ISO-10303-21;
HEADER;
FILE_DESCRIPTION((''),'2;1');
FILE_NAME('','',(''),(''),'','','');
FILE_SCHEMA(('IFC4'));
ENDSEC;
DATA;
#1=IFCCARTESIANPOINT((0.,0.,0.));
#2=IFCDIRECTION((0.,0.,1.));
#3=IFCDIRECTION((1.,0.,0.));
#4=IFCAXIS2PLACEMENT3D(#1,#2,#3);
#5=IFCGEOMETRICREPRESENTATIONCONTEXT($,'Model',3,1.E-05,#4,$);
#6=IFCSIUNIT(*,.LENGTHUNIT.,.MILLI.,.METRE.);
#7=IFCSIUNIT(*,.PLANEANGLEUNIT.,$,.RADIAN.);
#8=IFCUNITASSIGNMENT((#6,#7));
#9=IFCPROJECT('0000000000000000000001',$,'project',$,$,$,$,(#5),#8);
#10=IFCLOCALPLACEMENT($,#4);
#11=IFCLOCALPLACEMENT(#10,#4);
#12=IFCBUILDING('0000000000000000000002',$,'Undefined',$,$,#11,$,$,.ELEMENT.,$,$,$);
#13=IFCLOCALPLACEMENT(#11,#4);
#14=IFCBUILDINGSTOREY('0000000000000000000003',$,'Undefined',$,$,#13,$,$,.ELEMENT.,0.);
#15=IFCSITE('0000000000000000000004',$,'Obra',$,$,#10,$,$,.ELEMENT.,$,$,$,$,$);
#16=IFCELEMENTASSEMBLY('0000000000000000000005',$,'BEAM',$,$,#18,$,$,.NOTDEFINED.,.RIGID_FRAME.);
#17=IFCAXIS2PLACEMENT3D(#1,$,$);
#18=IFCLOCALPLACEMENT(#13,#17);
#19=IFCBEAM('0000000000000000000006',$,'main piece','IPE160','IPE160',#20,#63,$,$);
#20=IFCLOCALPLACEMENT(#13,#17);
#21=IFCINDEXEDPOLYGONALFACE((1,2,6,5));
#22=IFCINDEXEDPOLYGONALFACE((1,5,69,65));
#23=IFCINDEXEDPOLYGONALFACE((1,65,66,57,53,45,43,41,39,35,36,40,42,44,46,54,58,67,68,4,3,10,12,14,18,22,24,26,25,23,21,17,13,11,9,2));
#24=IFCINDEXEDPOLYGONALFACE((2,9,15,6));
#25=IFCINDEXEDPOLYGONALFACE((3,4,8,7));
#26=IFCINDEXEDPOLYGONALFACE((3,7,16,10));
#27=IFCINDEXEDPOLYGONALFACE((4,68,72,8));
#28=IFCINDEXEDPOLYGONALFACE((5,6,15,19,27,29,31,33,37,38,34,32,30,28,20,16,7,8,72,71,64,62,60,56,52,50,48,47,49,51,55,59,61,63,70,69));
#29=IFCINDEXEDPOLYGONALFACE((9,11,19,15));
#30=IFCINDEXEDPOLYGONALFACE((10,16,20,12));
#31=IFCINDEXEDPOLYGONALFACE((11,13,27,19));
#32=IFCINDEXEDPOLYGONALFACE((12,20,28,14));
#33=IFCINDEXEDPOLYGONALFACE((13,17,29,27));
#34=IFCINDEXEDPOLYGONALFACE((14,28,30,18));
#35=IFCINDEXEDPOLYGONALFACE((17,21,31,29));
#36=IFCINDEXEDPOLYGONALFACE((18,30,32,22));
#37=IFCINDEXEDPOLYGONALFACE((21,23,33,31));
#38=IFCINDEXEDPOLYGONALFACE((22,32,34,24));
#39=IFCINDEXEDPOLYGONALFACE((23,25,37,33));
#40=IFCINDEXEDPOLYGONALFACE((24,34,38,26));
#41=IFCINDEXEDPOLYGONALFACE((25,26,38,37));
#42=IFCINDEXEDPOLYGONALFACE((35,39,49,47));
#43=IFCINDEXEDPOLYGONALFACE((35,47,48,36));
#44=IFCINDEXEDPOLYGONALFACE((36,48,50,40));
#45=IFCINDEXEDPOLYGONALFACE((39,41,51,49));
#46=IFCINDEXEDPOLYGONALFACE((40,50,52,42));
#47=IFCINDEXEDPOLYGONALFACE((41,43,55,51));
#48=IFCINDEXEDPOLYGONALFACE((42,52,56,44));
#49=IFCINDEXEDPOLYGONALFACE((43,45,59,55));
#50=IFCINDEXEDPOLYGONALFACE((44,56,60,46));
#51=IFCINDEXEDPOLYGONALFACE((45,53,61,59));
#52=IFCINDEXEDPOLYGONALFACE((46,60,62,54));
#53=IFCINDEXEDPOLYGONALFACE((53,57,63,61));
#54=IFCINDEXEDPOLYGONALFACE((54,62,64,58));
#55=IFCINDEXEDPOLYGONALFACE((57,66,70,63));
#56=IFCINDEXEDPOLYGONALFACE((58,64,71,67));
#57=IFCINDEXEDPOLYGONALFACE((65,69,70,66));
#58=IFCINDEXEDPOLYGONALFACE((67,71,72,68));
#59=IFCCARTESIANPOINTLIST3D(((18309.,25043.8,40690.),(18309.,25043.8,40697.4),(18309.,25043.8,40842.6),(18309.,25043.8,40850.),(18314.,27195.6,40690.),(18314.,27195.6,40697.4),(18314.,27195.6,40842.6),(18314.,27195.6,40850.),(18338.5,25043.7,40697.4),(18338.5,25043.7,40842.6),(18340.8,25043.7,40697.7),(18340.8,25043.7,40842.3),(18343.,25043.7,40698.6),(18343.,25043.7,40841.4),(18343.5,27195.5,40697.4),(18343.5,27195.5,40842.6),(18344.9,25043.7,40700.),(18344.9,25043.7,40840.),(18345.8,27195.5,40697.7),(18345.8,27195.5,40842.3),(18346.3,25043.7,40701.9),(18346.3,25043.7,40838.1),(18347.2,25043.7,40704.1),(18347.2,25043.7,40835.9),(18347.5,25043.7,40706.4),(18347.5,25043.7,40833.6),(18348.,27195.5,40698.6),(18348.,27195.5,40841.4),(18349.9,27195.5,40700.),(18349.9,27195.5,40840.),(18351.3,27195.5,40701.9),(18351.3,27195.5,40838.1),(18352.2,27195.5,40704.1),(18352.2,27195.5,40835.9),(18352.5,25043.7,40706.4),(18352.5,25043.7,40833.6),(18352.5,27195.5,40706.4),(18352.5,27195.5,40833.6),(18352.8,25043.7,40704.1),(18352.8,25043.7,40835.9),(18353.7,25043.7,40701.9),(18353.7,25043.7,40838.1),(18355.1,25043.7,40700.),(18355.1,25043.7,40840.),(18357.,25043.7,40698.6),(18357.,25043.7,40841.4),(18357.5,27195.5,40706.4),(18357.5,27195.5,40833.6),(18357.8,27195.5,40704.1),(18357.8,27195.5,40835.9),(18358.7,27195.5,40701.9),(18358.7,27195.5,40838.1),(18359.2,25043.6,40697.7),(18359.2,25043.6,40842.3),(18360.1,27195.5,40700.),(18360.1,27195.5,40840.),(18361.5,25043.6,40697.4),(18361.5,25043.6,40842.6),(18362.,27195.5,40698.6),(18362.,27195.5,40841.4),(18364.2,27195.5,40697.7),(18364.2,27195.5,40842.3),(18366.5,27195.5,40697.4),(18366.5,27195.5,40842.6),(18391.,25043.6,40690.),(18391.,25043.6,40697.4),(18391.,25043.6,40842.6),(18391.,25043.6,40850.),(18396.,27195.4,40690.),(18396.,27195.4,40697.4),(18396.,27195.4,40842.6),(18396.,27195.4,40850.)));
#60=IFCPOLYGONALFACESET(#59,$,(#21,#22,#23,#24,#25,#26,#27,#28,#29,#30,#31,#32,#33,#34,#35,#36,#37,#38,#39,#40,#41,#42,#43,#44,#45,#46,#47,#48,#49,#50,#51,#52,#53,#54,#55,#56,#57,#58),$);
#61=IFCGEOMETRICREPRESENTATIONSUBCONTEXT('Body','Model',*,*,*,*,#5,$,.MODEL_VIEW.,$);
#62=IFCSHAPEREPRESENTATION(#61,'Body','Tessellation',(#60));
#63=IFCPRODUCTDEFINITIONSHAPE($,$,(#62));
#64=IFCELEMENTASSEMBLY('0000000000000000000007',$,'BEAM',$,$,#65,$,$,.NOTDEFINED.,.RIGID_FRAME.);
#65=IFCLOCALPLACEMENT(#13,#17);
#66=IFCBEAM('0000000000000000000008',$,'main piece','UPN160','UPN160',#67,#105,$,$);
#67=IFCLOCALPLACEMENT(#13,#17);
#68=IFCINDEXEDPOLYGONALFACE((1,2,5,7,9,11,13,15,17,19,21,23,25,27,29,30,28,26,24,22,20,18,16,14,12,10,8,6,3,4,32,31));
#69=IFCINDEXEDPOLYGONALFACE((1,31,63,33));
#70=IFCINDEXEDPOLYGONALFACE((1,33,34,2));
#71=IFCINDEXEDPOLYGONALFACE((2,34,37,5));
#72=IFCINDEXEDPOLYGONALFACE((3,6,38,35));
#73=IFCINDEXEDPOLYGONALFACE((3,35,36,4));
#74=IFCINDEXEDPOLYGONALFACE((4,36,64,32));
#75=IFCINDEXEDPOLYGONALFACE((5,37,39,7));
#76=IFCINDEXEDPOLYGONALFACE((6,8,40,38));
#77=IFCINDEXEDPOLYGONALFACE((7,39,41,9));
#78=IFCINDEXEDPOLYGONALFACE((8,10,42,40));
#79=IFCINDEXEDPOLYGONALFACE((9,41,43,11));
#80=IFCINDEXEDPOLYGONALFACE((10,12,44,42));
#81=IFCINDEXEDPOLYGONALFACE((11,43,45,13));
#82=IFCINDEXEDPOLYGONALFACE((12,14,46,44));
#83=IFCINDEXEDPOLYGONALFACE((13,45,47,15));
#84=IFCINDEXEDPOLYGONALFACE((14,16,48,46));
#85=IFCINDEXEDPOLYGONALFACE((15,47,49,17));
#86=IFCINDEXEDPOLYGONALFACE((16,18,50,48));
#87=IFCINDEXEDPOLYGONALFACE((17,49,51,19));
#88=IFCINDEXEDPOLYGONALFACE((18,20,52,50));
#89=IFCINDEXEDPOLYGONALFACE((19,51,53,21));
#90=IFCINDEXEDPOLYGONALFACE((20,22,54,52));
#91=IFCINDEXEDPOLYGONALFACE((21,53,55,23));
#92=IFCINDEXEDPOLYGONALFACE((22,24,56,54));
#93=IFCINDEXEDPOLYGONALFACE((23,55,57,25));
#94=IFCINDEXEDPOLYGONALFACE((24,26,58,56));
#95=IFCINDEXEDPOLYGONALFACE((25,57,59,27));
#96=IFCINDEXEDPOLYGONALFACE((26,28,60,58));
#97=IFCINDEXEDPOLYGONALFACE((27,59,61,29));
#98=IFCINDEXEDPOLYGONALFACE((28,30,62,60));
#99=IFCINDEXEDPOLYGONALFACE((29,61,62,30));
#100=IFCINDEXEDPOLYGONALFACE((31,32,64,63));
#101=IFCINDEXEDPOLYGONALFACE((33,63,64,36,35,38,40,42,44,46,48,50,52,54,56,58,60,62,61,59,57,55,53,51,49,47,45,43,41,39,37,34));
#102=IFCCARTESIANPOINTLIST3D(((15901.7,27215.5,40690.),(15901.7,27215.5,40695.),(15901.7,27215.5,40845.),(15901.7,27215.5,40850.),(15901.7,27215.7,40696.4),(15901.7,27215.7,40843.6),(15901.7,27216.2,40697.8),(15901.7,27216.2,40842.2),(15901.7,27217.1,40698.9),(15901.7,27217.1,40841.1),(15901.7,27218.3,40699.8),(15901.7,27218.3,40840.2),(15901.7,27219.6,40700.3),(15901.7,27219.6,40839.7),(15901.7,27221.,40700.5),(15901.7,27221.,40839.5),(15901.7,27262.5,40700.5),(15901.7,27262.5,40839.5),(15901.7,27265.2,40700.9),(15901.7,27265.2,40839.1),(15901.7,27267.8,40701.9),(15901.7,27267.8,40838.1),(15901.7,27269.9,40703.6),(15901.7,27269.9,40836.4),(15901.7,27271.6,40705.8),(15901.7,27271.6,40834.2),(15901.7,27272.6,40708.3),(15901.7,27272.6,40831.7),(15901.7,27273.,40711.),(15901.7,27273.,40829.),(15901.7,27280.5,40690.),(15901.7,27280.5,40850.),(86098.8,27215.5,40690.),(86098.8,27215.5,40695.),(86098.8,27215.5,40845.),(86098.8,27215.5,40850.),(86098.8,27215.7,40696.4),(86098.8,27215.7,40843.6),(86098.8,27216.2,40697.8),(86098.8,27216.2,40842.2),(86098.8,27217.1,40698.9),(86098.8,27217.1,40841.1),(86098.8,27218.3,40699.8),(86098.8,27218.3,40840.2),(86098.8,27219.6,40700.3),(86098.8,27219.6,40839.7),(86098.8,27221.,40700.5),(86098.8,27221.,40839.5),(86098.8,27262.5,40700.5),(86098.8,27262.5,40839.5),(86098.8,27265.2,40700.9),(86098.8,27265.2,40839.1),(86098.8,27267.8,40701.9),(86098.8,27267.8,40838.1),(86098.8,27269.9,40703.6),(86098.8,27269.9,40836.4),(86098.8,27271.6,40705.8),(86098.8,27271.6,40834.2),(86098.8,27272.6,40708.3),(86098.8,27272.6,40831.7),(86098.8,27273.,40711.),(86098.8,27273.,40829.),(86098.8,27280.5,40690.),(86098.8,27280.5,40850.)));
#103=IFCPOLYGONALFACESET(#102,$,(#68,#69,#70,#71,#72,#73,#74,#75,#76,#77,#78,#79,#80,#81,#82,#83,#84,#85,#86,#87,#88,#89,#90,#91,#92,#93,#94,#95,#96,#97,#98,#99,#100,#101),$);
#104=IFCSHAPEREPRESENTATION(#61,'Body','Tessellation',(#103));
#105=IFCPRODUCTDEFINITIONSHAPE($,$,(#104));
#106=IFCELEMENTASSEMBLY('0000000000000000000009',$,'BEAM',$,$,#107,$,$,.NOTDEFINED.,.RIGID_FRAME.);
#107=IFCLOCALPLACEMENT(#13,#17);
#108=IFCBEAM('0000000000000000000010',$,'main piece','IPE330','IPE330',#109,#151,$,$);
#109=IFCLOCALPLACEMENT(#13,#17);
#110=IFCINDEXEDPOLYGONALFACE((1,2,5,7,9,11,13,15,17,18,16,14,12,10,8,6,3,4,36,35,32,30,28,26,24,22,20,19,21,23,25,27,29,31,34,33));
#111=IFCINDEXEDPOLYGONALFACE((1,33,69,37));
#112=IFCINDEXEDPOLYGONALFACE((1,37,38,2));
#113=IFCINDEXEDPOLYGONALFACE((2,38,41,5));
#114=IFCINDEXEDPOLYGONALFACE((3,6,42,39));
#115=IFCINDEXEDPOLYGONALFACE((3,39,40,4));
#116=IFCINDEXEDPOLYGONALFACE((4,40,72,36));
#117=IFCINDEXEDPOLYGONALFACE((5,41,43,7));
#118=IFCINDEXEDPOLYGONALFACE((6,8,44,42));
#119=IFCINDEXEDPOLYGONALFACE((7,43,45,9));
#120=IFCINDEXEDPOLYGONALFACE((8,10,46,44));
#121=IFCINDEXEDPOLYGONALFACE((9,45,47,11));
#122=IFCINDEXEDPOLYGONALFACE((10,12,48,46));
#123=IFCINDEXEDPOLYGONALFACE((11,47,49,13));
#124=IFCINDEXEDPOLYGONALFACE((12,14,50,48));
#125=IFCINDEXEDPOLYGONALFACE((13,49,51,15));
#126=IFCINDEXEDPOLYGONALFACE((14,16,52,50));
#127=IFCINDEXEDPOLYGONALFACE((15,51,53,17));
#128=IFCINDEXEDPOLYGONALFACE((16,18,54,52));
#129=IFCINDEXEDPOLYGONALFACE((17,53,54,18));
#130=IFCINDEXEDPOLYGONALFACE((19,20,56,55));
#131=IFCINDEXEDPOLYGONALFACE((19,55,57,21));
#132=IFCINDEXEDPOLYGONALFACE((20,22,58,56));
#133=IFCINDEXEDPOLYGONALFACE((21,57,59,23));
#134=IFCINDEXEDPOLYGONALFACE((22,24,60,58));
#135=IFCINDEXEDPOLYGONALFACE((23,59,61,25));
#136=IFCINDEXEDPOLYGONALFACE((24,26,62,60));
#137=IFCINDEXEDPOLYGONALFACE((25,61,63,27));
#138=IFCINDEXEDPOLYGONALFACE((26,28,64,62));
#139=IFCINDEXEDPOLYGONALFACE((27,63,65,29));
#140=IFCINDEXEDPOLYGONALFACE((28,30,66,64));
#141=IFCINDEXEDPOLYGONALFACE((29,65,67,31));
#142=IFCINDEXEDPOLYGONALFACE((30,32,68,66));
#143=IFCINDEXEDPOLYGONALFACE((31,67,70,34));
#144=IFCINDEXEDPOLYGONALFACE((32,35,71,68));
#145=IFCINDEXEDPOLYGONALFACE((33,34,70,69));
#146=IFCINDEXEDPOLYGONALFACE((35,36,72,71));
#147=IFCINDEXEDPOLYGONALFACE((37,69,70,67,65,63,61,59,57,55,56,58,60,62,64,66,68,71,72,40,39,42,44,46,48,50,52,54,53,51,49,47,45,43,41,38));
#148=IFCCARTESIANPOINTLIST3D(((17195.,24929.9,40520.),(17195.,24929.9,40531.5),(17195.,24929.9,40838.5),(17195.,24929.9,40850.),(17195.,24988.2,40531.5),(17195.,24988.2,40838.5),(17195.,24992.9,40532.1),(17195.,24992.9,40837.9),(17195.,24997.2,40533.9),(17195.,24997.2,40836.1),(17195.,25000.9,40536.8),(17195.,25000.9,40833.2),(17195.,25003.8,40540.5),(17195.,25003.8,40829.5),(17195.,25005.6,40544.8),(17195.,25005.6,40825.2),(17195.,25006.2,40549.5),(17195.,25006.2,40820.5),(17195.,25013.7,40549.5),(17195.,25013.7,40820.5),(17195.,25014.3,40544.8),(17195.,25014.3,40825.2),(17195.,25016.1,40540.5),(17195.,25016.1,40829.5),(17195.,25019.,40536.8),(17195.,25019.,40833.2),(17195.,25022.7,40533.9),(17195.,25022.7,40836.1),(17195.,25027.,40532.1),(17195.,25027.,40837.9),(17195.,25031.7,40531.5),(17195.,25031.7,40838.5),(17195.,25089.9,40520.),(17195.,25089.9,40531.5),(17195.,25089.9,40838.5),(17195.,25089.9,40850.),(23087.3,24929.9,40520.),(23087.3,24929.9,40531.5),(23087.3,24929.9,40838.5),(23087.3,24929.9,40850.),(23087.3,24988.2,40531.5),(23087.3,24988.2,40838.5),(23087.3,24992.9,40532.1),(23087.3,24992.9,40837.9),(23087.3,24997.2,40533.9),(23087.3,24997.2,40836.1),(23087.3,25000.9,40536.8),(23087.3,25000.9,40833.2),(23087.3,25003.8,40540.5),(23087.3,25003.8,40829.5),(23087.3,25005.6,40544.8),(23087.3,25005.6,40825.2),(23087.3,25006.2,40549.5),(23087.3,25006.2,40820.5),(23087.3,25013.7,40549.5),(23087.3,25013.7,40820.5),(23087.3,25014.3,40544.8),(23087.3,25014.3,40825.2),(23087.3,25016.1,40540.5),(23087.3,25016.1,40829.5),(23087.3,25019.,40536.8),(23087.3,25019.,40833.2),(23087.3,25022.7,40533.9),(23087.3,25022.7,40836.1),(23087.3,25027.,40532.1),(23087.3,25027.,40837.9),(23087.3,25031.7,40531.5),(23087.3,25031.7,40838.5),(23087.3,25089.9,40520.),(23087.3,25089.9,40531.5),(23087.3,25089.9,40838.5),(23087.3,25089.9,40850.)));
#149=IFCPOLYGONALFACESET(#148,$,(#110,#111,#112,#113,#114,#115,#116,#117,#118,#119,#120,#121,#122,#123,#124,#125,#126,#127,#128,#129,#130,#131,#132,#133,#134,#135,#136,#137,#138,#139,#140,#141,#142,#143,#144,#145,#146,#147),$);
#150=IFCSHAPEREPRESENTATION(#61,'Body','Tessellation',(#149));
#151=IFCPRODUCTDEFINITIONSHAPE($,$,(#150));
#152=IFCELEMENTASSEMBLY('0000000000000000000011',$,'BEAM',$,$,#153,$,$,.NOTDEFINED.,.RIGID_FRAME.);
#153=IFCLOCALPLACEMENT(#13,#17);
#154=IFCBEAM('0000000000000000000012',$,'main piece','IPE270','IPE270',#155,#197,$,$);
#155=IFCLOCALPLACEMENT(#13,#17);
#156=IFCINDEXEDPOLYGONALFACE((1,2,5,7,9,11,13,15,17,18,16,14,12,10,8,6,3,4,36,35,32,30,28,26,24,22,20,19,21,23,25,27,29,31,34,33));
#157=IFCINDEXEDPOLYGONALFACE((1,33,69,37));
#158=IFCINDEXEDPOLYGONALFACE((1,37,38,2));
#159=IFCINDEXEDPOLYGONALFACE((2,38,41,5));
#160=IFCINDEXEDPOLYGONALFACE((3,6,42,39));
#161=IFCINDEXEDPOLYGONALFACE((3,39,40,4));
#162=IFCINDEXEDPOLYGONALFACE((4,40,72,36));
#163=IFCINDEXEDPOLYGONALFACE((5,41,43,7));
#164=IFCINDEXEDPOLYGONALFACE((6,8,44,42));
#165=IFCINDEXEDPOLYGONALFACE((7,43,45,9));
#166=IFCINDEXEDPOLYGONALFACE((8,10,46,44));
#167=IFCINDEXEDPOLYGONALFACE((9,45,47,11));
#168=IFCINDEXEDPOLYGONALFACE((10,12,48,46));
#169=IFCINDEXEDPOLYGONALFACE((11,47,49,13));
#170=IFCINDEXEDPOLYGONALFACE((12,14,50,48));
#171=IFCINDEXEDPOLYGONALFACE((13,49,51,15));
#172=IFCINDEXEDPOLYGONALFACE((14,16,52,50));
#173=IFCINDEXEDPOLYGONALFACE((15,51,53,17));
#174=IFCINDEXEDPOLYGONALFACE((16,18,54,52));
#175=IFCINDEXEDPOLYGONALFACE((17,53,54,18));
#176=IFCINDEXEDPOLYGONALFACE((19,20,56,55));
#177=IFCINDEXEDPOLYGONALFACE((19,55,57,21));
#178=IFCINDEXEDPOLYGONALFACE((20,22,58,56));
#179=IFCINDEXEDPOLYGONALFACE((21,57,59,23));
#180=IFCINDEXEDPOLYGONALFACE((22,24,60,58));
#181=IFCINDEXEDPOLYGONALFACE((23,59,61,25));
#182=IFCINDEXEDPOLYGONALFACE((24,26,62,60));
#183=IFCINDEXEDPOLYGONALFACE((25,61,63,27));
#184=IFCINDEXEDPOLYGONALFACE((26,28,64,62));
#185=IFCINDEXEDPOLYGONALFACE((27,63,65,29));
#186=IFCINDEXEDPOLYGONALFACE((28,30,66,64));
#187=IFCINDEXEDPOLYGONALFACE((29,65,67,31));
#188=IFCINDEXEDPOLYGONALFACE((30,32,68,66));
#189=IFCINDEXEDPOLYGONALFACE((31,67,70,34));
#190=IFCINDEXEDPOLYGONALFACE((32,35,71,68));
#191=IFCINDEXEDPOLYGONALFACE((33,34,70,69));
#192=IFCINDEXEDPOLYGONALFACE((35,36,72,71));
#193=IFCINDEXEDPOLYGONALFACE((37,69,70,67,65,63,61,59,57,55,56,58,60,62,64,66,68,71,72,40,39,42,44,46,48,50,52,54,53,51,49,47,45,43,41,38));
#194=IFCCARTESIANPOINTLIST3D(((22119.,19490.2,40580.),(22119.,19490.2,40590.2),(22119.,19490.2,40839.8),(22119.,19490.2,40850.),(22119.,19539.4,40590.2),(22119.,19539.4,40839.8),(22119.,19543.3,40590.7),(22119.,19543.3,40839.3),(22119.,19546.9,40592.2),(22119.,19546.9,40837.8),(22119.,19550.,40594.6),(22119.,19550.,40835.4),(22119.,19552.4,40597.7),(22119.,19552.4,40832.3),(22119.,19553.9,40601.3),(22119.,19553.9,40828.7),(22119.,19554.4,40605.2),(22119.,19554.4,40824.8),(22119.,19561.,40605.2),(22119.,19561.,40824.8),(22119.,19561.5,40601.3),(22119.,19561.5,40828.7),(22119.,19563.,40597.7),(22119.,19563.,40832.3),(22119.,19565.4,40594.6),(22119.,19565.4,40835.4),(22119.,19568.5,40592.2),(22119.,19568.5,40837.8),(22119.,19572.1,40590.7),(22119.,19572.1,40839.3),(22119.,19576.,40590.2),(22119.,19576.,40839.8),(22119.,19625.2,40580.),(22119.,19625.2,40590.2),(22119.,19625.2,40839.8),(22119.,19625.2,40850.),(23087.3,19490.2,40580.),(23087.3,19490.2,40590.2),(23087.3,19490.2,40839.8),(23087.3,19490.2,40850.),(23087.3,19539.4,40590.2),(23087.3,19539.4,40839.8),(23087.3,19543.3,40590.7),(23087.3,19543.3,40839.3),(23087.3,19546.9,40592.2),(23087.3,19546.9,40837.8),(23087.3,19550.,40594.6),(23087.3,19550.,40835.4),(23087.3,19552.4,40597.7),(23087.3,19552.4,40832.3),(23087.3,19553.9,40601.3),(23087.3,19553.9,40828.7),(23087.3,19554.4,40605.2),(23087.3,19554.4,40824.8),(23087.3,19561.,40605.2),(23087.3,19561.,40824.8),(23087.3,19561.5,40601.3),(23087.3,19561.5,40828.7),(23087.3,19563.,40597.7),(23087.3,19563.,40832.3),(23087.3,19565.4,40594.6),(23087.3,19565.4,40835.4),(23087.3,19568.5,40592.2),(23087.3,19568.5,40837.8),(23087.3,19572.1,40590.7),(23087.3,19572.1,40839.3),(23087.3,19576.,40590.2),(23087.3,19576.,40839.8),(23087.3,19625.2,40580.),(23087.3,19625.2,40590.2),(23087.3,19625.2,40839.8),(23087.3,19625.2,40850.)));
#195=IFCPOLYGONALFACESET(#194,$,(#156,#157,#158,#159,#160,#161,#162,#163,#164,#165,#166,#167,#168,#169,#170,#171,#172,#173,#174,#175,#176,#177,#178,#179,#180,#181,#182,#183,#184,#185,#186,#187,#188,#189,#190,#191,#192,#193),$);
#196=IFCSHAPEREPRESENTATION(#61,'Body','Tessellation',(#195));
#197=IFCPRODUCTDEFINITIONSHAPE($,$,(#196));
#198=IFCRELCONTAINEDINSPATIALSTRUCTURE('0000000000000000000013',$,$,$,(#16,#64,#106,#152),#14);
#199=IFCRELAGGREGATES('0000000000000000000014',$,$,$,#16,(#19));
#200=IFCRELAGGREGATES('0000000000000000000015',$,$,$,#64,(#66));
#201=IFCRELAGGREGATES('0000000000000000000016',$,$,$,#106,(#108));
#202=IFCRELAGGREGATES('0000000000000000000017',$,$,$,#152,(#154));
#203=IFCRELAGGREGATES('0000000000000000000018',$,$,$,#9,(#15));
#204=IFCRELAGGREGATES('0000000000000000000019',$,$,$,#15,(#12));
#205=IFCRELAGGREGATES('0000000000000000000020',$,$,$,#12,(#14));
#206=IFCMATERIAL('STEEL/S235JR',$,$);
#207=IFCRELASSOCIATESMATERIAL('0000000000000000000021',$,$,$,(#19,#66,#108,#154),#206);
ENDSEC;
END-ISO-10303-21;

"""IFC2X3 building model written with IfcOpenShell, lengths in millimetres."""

from ifc_helpers import new_model, si_unit, frame, origin_with_axes, origin_2d_with_axis, place, context, subcontext, project, spatial, i_section, u_section, extrude, material, element, aggregate, save


model = new_model("IFC2X3")

# Units and contexts
model_context = context("Model", 3, precision=1e-05, world=origin_with_axes())
body_context = subcontext(model_context, "Body", "Model", "MODEL_VIEW")
ifc_project = project(units=[si_unit("LENGTHUNIT", "METRE", prefix="MILLI"), si_unit("PLANEANGLEUNIT", "RADIAN")], contexts=[model_context])

# Site, building, storey
site_placement = place(None, origin_with_axes())
site = spatial("IfcSite", under=ifc_project, at=site_placement, Name="Obra", CompositionType="ELEMENT")
building_placement = place(site_placement, origin_with_axes())
building = spatial("IfcBuilding", under=site, at=building_placement, Name="Undefined", CompositionType="ELEMENT")
storey_placement = place(building_placement, origin_with_axes())
storey = spatial("IfcBuildingStorey", under=building, at=storey_placement, Name="Undefined", CompositionType="ELEMENT", Elevation=0.0)

# Shared definitions
ifc_material_1 = material(Name="STEEL/S235JR")

# Element assemblies, beams
assembly_1_placement = place(storey_placement, origin_with_axes())
assembly_1 = element("IfcElementAssembly", 1, at=assembly_1_placement, inside=storey, Name="BEAM", AssemblyPlace="NOTDEFINED", PredefinedType="RIGID_FRAME")
beam_1_placement = place(assembly_1_placement, frame((18350.0, 25043.7, 40770.0), z_axis=(0.0, 0.0, 1.0), x_axis=(0.002325, 0.999997, 0.0)))
beam_1 = element("IfcBeam", 2, at=beam_1_placement, material=ifc_material_1, Name="main piece", Description="IPE160", ObjectType="IPE160", context=body_context, shape_type="SweptSolid", body=[
    extrude(i_section(OverallWidth=82.0, OverallDepth=160.0, WebThickness=5.0, FlangeThickness=7.4, FilletRadius=9.0, at=origin_2d_with_axis()), frame((2151.8, 0.0, 0.0), z_axis=(-1.0, 0.0, 0.0), x_axis=(0.0, -1.0, 0.0)), (0.0, 0.0, 1.0), 2151.8),
])
aggregate(assembly_1, [beam_1])
assembly_2_placement = place(storey_placement, origin_with_axes())
assembly_2 = element("IfcElementAssembly", 3, at=assembly_2_placement, inside=storey, Name="BEAM", AssemblyPlace="NOTDEFINED", PredefinedType="RIGID_FRAME")
beam_2_placement = place(assembly_2_placement, frame((15901.7, 27248.0, 40770.0), z_axis=(0.0, 0.0, 1.0), x_axis=(1.0, 0.0, 0.0)))
beam_2 = element("IfcBeam", 4, at=beam_2_placement, material=ifc_material_1, Name="main piece", Description="UPN160", ObjectType="UPN160", context=body_context, shape_type="SweptSolid", body=[
    extrude(u_section(Depth=160.0, FlangeWidth=65.0, WebThickness=7.5, FlangeThickness=10.5, FilletRadius=10.5, EdgeRadius=5.5, at=origin_2d_with_axis()), frame((70197.1, 0.0, 0.0), z_axis=(-1.0, 0.0, 0.0), x_axis=(0.0, -1.0, 0.0)), (0.0, 0.0, 1.0), 70197.1),
])
aggregate(assembly_2, [beam_2])
assembly_3_placement = place(storey_placement, origin_with_axes())
assembly_3 = element("IfcElementAssembly", 5, at=assembly_3_placement, inside=storey, Name="BEAM", AssemblyPlace="NOTDEFINED", PredefinedType="RIGID_FRAME")
beam_3_placement = place(assembly_3_placement, frame((17195.0, 25009.9, 40685.0), z_axis=(0.0, 0.0, 1.0), x_axis=(1.0, 0.0, 0.0)))
beam_3 = element("IfcBeam", 6, at=beam_3_placement, material=ifc_material_1, Name="main piece", Description="IPE330", ObjectType="IPE330", context=body_context, shape_type="SweptSolid", body=[
    extrude(i_section(OverallWidth=160.0, OverallDepth=330.0, WebThickness=7.5, FlangeThickness=11.5, FilletRadius=18.0, at=origin_2d_with_axis()), frame((5892.3, 0.0, 0.0), z_axis=(-1.0, 0.0, 0.0), x_axis=(0.0, -1.0, 0.0)), (0.0, 0.0, 1.0), 5892.3),
])
aggregate(assembly_3, [beam_3])
assembly_4_placement = place(storey_placement, origin_with_axes())
assembly_4 = element("IfcElementAssembly", 7, at=assembly_4_placement, inside=storey, Name="BEAM", AssemblyPlace="NOTDEFINED", PredefinedType="RIGID_FRAME")
beam_4_placement = place(assembly_4_placement, frame((22119.0, 19557.7, 40715.0), z_axis=(0.0, 0.0, 1.0), x_axis=(1.0, 0.0, 0.0)))
beam_4 = element("IfcBeam", 8, at=beam_4_placement, material=ifc_material_1, Name="main piece", Description="IPE270", ObjectType="IPE270", context=body_context, shape_type="SweptSolid", body=[
    extrude(i_section(OverallWidth=135.0, OverallDepth=270.0, WebThickness=6.6, FlangeThickness=10.2, FilletRadius=15.0, at=origin_2d_with_axis()), frame((968.2, 0.0, 0.0), z_axis=(-1.0, 0.0, 0.0), x_axis=(0.0, -1.0, 0.0)), (0.0, 0.0, 1.0), 968.2),
])
aggregate(assembly_4, [beam_4])

save(model, "model.ifc")
